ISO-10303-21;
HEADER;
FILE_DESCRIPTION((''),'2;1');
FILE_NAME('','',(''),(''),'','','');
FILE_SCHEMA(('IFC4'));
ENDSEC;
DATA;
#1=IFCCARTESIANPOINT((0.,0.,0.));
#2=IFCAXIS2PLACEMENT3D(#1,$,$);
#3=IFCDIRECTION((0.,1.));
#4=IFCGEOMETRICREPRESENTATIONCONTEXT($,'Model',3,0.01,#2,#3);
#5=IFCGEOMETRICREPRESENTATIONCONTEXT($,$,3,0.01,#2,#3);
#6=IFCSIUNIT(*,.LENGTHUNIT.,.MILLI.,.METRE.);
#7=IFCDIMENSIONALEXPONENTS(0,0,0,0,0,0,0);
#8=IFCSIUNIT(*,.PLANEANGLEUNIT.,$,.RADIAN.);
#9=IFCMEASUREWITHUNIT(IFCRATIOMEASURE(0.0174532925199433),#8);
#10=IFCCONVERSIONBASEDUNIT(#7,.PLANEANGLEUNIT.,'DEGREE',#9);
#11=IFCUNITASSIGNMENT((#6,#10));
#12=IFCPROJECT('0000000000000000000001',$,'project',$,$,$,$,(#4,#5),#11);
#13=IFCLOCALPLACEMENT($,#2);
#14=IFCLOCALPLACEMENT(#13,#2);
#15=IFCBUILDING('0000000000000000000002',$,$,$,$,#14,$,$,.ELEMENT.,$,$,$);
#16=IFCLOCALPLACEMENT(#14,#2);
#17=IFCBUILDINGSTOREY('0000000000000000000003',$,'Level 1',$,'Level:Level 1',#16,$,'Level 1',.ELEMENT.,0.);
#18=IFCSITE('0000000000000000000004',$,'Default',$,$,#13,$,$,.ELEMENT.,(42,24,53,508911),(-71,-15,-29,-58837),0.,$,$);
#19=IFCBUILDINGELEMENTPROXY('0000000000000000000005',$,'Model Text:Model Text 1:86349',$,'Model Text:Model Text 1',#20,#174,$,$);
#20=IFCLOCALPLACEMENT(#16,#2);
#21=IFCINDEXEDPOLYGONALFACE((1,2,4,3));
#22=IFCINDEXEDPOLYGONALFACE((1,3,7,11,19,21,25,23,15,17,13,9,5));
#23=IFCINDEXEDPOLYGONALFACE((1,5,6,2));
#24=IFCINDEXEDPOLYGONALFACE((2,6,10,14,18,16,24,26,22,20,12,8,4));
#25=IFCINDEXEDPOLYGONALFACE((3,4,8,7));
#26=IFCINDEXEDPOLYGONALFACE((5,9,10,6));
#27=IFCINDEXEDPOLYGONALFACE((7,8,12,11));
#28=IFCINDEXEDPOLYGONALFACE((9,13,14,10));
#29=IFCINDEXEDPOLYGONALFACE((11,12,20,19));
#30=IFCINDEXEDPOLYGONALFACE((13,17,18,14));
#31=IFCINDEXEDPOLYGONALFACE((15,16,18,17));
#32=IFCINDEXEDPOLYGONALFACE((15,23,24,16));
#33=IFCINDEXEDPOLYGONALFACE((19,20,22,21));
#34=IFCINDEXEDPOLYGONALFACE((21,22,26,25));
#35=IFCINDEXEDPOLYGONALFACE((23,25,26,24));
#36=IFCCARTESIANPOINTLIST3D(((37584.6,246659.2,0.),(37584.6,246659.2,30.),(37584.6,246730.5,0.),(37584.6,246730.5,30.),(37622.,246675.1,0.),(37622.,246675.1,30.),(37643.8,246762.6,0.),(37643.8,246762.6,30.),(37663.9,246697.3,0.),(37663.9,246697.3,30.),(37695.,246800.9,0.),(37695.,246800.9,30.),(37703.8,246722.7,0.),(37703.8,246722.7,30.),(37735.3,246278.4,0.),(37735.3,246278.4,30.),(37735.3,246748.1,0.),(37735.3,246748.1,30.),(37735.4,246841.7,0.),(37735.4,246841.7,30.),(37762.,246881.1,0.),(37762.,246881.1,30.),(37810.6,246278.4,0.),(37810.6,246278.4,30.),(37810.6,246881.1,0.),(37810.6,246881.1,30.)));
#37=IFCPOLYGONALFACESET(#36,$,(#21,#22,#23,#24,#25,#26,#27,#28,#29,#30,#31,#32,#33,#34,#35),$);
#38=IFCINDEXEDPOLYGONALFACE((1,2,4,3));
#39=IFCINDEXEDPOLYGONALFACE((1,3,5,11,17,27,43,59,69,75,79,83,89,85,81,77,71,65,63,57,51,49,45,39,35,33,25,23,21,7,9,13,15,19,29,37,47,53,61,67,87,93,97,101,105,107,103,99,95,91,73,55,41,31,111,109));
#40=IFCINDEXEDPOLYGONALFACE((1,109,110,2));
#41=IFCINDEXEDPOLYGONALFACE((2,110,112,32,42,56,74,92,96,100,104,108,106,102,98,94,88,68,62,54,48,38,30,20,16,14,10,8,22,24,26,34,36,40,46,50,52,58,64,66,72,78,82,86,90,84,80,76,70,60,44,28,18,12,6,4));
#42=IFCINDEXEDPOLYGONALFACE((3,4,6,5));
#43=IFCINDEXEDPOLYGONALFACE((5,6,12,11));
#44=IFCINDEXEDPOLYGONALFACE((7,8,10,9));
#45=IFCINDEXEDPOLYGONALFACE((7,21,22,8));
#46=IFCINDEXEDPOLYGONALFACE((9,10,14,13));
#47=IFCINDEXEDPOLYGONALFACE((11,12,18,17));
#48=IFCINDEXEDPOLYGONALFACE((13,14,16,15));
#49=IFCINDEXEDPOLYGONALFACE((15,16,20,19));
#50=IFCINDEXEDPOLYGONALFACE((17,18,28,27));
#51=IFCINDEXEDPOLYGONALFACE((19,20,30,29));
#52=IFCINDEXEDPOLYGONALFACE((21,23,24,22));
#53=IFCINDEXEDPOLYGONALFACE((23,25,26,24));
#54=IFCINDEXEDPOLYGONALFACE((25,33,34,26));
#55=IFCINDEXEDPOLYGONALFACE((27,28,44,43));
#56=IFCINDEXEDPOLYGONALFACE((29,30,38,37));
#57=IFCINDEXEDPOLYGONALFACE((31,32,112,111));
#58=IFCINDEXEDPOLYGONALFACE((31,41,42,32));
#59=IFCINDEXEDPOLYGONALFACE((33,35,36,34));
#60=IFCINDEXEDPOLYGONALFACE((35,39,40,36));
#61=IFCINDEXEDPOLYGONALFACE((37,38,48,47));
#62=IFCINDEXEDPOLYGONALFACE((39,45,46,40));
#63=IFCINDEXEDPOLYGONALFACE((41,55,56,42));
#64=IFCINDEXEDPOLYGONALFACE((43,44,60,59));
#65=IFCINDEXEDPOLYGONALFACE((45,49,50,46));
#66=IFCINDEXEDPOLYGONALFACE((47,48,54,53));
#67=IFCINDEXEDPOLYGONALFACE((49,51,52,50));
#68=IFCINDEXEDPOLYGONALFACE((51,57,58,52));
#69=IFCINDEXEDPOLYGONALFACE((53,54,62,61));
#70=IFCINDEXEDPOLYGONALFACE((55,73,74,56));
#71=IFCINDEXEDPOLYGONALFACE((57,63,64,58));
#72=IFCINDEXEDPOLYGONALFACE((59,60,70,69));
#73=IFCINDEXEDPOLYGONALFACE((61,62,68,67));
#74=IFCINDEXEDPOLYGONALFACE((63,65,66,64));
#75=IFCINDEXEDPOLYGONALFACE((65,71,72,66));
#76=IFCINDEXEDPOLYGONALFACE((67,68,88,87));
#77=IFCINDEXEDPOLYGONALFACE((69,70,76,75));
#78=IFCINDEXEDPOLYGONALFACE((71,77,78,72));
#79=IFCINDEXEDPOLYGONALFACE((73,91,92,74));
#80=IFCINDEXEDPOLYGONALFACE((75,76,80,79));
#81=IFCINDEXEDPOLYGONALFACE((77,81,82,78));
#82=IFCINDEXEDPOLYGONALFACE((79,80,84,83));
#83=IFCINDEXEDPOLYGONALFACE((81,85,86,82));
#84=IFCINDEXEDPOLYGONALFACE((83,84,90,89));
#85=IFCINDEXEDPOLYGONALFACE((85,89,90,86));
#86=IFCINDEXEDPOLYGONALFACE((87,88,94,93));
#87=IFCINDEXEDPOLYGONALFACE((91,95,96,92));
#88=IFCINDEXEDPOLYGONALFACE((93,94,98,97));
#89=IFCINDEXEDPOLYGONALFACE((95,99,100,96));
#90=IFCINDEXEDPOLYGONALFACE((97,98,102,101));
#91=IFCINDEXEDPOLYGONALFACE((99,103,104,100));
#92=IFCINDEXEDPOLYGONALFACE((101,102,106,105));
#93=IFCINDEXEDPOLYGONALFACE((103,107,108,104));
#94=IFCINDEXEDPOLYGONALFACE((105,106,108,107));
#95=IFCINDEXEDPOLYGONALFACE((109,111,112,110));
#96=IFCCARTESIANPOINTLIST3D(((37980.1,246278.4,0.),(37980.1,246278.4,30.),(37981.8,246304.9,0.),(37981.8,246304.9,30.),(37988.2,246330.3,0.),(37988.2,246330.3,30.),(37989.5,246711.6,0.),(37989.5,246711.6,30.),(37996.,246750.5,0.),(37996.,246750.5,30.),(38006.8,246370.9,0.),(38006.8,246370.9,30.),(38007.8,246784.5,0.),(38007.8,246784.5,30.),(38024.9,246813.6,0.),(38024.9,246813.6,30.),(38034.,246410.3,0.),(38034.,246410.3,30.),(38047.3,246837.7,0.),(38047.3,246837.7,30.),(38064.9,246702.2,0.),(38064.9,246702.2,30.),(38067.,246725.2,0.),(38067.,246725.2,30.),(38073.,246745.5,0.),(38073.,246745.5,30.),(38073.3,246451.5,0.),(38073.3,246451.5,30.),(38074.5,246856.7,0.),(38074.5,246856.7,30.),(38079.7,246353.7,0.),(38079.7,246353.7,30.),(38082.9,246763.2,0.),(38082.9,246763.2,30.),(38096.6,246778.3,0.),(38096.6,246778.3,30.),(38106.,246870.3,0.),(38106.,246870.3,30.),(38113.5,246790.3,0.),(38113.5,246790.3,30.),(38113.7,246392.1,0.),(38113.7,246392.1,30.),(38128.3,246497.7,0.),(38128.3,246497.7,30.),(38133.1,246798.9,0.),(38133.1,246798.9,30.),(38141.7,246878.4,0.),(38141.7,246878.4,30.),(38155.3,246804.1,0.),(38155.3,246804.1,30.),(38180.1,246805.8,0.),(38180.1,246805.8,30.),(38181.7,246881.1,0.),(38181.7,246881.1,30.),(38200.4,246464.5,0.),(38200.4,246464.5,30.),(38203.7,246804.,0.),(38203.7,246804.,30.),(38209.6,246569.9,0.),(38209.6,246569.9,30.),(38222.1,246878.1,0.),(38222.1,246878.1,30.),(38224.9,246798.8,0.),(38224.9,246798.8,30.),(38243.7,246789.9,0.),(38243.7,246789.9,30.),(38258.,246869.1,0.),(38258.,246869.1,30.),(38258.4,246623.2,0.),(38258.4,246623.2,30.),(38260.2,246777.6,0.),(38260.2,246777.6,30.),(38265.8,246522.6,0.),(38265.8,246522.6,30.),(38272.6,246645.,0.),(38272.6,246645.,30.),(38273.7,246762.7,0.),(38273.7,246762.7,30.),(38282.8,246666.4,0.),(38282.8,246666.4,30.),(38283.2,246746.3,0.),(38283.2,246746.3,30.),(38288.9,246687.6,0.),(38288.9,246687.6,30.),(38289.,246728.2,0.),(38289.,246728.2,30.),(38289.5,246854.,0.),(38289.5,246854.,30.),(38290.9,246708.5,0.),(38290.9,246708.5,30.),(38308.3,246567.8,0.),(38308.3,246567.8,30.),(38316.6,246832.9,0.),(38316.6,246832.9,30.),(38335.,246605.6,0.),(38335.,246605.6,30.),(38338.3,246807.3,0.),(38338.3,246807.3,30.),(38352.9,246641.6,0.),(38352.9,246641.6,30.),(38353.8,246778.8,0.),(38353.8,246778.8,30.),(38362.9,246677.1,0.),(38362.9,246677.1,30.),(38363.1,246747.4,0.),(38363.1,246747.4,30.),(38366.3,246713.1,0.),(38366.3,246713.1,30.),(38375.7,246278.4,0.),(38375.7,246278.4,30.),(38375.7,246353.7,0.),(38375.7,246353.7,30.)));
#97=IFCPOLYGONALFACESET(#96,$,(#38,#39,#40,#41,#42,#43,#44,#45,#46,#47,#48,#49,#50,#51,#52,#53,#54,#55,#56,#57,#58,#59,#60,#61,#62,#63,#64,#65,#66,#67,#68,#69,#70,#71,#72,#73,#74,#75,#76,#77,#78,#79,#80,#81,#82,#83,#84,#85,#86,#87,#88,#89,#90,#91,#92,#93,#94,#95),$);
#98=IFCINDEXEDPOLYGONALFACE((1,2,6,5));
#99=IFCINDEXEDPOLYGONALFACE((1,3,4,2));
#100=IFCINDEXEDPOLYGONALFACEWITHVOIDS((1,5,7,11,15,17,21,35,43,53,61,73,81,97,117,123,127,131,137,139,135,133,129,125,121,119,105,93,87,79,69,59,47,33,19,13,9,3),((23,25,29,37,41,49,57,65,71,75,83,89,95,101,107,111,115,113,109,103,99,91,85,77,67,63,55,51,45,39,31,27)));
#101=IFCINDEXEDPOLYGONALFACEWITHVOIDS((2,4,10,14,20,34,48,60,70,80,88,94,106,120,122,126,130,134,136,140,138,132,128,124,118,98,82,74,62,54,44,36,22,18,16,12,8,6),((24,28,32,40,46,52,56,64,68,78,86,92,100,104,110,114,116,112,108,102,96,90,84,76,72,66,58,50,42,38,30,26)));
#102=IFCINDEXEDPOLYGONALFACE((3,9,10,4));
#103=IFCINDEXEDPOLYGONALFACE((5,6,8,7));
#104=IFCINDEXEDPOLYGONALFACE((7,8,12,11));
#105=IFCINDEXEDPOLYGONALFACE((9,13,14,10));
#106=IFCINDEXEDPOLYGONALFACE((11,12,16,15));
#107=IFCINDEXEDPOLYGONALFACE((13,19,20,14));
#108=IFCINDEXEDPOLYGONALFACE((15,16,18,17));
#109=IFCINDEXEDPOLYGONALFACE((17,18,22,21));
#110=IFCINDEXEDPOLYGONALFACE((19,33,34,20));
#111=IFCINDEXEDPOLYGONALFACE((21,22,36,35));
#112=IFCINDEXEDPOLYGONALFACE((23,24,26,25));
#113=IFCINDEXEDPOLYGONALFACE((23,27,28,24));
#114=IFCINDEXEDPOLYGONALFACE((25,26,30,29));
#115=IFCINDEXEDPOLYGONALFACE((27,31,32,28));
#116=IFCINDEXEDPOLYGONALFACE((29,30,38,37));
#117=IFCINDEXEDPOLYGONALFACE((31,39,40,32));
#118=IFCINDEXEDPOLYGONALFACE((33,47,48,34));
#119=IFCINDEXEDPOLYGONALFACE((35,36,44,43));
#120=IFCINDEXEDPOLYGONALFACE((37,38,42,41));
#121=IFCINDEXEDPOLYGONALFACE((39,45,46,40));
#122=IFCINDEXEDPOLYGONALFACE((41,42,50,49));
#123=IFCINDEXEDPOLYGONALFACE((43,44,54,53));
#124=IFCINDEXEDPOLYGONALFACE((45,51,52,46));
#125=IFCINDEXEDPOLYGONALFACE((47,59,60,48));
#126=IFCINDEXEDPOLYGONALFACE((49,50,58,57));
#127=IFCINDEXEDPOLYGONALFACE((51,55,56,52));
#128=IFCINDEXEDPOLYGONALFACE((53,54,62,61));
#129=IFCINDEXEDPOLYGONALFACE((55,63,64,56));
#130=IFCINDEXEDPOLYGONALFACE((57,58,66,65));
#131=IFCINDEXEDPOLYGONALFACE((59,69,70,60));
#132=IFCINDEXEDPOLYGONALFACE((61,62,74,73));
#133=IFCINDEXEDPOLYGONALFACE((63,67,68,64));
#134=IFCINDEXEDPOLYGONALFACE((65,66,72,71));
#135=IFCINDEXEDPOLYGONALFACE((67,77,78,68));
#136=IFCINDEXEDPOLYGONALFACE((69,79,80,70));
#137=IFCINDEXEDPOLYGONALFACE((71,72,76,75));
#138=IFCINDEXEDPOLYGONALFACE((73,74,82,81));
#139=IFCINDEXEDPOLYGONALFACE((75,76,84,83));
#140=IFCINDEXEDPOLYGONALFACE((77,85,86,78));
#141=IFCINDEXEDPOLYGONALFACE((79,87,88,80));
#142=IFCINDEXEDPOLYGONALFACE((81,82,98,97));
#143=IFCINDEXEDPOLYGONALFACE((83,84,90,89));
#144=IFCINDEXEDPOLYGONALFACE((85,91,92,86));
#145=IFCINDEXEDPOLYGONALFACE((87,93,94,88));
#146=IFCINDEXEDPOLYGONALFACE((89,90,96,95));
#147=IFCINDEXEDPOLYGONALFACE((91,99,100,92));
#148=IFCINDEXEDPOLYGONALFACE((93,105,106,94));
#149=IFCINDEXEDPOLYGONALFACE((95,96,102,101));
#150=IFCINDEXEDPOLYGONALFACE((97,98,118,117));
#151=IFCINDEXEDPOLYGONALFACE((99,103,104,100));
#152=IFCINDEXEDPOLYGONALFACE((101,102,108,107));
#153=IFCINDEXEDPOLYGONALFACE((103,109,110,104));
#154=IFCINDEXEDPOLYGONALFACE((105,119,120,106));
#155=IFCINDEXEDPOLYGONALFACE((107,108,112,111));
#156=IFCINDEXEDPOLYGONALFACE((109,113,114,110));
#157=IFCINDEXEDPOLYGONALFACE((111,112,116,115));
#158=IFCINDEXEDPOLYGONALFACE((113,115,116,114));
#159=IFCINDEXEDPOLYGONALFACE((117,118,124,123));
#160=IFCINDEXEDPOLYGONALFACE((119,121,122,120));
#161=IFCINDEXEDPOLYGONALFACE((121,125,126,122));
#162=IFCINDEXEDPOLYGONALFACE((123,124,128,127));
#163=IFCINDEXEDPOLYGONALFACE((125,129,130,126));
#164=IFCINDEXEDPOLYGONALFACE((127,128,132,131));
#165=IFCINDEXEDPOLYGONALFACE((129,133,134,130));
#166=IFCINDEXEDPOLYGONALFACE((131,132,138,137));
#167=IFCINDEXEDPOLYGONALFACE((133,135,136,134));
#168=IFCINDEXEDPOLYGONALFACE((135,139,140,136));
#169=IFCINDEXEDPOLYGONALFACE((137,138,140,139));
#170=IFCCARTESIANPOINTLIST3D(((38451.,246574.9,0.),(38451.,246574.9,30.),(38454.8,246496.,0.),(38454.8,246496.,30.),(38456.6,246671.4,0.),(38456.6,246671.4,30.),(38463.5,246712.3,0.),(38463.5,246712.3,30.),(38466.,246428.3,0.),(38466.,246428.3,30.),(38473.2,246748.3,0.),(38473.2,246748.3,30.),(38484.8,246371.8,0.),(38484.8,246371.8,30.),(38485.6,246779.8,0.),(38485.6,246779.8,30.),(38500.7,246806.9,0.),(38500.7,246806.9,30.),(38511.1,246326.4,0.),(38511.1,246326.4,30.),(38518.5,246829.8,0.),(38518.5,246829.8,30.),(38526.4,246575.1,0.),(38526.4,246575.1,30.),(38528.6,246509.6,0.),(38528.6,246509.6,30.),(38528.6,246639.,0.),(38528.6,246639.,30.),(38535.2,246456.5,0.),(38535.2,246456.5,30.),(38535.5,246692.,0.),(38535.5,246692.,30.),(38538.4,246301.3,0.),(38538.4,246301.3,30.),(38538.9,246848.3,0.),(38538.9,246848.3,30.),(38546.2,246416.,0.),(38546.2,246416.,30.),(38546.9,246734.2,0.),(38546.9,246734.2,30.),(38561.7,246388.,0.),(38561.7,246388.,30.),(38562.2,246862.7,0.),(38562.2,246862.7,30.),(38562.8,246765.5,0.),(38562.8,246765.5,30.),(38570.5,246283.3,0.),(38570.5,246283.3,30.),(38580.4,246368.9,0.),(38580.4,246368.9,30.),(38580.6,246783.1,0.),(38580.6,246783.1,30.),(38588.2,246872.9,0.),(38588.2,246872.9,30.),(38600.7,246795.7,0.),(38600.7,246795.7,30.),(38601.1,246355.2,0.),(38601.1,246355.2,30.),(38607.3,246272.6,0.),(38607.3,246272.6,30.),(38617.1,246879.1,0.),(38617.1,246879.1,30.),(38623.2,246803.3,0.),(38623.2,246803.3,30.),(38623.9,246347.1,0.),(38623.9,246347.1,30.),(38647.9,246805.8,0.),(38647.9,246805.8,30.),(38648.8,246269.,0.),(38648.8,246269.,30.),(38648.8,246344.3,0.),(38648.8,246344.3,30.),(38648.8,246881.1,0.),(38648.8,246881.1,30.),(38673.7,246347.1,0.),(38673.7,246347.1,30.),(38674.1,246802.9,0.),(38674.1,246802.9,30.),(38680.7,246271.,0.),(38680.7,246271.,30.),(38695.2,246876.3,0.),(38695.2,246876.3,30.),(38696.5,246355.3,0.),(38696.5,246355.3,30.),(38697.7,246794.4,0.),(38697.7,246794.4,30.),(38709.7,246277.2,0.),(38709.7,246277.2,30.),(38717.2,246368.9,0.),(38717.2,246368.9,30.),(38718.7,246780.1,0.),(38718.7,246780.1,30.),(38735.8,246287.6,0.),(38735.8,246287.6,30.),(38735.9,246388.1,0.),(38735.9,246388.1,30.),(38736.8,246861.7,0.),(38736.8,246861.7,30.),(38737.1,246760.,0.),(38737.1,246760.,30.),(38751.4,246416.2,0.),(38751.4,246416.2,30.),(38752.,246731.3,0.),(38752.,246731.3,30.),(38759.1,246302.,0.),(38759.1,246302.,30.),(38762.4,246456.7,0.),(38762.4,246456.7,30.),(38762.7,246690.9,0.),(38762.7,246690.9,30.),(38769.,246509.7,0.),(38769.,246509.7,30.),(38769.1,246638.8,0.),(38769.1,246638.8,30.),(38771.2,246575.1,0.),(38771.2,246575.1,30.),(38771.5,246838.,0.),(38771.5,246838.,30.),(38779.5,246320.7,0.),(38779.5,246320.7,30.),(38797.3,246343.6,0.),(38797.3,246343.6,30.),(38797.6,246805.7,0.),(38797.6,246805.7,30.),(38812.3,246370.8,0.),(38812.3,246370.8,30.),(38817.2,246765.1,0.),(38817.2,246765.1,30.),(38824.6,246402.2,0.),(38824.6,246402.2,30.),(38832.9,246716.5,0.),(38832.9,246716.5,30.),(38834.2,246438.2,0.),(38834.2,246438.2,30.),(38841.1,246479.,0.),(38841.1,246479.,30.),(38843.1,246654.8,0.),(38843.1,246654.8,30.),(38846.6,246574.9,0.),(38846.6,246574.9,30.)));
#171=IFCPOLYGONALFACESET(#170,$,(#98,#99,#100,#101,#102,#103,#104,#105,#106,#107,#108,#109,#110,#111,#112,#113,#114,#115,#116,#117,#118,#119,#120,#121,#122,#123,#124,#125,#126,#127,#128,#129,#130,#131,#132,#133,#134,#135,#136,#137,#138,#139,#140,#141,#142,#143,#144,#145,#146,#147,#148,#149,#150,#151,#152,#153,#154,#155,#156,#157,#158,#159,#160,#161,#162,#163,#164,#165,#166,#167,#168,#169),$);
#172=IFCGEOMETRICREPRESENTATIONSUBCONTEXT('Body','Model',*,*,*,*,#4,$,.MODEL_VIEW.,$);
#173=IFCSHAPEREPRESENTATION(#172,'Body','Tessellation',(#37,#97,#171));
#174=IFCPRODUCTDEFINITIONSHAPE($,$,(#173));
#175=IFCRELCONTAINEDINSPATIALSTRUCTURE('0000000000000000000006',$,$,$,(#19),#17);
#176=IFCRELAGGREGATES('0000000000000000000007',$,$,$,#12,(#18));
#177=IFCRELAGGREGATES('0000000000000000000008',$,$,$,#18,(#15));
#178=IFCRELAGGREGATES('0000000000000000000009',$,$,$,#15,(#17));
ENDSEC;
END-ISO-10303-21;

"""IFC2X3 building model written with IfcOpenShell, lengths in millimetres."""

from ifc_helpers import new_model, entity, si_unit, converted_unit, direction, frame, origin, place, context, subcontext, project, spatial, polyline, outline, extrude, element, save


model = new_model("IFC2X3")

# Units and contexts
model_context = context("Model", 3, precision=0.01, world=origin(), true_north=direction((0.0, 1.0)))
context_of_model = context(None, 3, precision=0.01, world=origin(), true_north=direction((0.0, 1.0)))
body_context = subcontext(model_context, "Body", "Model", "MODEL_VIEW")
ifc_project = project(units=[si_unit("LENGTHUNIT", "METRE", prefix="MILLI"), converted_unit("PLANEANGLEUNIT", "DEGREE", entity("IfcRatioMeasure", 0.0174532925199433), si_unit("PLANEANGLEUNIT", "RADIAN"), dimensions=[0, 0, 0, 0, 0, 0, 0])], contexts=[model_context, context_of_model])

# Site, building, storey
site_placement = place(None, origin())
site = spatial("IfcSite", under=ifc_project, at=site_placement, Name="Default", CompositionType="ELEMENT", RefLatitude=(42, 24, 53, 508911), RefLongitude=(-71, -15, -29, -58837), RefElevation=0.0)
building_placement = place(site_placement, origin())
building = spatial("IfcBuilding", under=site, at=building_placement, CompositionType="ELEMENT")
storey_placement = place(building_placement, origin())
storey = spatial("IfcBuildingStorey", under=building, at=storey_placement, Name="Level 1", ObjectType="Level:Level 1", LongName="Level 1", CompositionType="ELEMENT", Elevation=0.0)

# Building element proxy
proxy_1_placement = place(storey_placement, origin())
element("IfcBuildingElementProxy", 1, at=proxy_1_placement, inside=storey, Name="Model Text:Model Text 1:86349", ObjectType="Model Text:Model Text 1", context=body_context, shape_type="SweptSolid", body=[
    extrude(outline(polyline([(-410.6, -111.6), (192.1, -111.6), (192.1, -63.1), (152.7, -36.4), (111.9, 4.0), (73.6, 55.2), (41.4, 114.4), (-29.8, 114.4), (-13.9, 77.0), (8.3, 35.1), (33.7, -4.8), (59.1, -36.3), (-410.6, -36.3), (-410.6, -111.6)])), frame((37699.0, 246689.0, 0.0), z_axis=(0.0, 0.0, 1.0), x_axis=(0.0, 1.0, 0.0)), (0.0, 0.0, 1.0), 30.0),
    extrude(outline(polyline([(-190.2, -317.5), (-190.2, -392.8), (205.4, -392.8), (203.7, -366.3), (197.3, -340.9), (178.7, -300.3), (151.5, -260.9), (112.2, -219.7), (57.2, -173.6), (-24.1, -101.3), (-72.9, -48.0), (-87.1, -26.3), (-97.3, -4.8), (-103.4, 16.4), (-105.4, 37.3), (-103.5, 57.0), (-97.7, 75.0), (-88.2, 91.5), (-74.7, 106.4), (-58.2, 118.7), (-39.4, 127.5), (-18.2, 132.8), (5.4, 134.6), (30.2, 132.9), (52.4, 127.7), (72.0, 119.1), (88.9, 107.1), (102.6, 92.0), (112.5, 74.3), (118.5, 54.0), (120.6, 31.0), (196.0, 40.4), (189.5, 79.3), (177.7, 113.3), (160.6, 142.4), (138.2, 166.5), (111.0, 185.5), (79.5, 199.1), (43.8, 207.2), (3.8, 209.9), (-36.6, 206.9), (-72.5, 197.9), (-104.0, 182.8), (-131.1, 161.7), (-152.8, 136.1), (-168.3, 107.6), (-177.6, 76.2), (-180.8, 41.9), (-177.4, 5.8), (-167.4, -29.6), (-149.5, -65.6), (-122.8, -103.4), (-80.3, -148.6), (-14.9, -206.7), (71.8, -279.1), (105.8, -317.5), (-190.2, -317.5)])), frame((38185.5, 246671.2, 0.0), z_axis=(0.0, 0.0, -1.0), x_axis=(-1.0, 0.0, 0.0)), (0.0, 0.0, -1.0), 30.0),
    extrude(outline(polyline([(-10.6, -198.7), (68.3, -198.7), (136.5, -190.7), (193.9, -174.7), (240.5, -150.6), (266.9, -124.4), (286.3, -93.2), (298.8, -57.0), (304.3, -15.7), (303.8, 16.2), (299.0, 45.5), (289.9, 72.1), (276.6, 96.0), (258.9, 117.3), (236.9, 136.2), (210.4, 152.5), (179.6, 166.3), (144.1, 177.6), (103.7, 186.3), (8.2, 196.4), (-71.8, 196.7), (-134.0, 189.4), (-183.3, 176.1), (-224.7, 158.4), (-258.2, 133.9), (-283.5, 100.3), (-300.1, 59.5), (-307.1, 13.4), (-306.6, -18.4), (-301.8, -47.5), (-292.8, -74.0), (-279.6, -97.9), (-262.0, -119.2), (-240.0, -138.1), (-213.6, -154.5), (-182.8, -168.4), (-147.3, -179.8), (-106.7, -188.6), (-10.6, -198.7)]), holes=[polyline([(-7.2, -123.5), (-71.0, -118.2), (-123.6, -108.8), (-165.2, -95.4), (-195.7, -78.0), (-212.4, -59.4), (-224.1, -38.7), (-230.6, -15.9), (-231.9, 8.9), (-227.8, 35.0), (-218.1, 58.1), (-202.8, 78.4), (-182.0, 95.8), (-152.6, 109.4), (-111.7, 118.1), (-59.4, 122.0), (4.4, 121.1), (69.6, 115.8), (122.2, 106.7), (162.2, 93.7), (189.5, 77.0), (207.7, 57.4), (220.4, 36.0), (227.5, 12.8), (229.1, -12.1), (225.2, -36.8), (215.9, -59.2), (201.3, -79.3), (181.4, -97.1), (152.6, -111.2), (111.6, -120.3), (58.3, -124.4), (-7.2, -123.5)])]), frame((38650.0, 246573.7, 0.0), z_axis=(0.0, 0.0, 1.0), x_axis=(0.047515, -0.998871, 0.0)), (0.0, 0.0, 1.0), 30.0),
])

save(model, "model.ifc")
